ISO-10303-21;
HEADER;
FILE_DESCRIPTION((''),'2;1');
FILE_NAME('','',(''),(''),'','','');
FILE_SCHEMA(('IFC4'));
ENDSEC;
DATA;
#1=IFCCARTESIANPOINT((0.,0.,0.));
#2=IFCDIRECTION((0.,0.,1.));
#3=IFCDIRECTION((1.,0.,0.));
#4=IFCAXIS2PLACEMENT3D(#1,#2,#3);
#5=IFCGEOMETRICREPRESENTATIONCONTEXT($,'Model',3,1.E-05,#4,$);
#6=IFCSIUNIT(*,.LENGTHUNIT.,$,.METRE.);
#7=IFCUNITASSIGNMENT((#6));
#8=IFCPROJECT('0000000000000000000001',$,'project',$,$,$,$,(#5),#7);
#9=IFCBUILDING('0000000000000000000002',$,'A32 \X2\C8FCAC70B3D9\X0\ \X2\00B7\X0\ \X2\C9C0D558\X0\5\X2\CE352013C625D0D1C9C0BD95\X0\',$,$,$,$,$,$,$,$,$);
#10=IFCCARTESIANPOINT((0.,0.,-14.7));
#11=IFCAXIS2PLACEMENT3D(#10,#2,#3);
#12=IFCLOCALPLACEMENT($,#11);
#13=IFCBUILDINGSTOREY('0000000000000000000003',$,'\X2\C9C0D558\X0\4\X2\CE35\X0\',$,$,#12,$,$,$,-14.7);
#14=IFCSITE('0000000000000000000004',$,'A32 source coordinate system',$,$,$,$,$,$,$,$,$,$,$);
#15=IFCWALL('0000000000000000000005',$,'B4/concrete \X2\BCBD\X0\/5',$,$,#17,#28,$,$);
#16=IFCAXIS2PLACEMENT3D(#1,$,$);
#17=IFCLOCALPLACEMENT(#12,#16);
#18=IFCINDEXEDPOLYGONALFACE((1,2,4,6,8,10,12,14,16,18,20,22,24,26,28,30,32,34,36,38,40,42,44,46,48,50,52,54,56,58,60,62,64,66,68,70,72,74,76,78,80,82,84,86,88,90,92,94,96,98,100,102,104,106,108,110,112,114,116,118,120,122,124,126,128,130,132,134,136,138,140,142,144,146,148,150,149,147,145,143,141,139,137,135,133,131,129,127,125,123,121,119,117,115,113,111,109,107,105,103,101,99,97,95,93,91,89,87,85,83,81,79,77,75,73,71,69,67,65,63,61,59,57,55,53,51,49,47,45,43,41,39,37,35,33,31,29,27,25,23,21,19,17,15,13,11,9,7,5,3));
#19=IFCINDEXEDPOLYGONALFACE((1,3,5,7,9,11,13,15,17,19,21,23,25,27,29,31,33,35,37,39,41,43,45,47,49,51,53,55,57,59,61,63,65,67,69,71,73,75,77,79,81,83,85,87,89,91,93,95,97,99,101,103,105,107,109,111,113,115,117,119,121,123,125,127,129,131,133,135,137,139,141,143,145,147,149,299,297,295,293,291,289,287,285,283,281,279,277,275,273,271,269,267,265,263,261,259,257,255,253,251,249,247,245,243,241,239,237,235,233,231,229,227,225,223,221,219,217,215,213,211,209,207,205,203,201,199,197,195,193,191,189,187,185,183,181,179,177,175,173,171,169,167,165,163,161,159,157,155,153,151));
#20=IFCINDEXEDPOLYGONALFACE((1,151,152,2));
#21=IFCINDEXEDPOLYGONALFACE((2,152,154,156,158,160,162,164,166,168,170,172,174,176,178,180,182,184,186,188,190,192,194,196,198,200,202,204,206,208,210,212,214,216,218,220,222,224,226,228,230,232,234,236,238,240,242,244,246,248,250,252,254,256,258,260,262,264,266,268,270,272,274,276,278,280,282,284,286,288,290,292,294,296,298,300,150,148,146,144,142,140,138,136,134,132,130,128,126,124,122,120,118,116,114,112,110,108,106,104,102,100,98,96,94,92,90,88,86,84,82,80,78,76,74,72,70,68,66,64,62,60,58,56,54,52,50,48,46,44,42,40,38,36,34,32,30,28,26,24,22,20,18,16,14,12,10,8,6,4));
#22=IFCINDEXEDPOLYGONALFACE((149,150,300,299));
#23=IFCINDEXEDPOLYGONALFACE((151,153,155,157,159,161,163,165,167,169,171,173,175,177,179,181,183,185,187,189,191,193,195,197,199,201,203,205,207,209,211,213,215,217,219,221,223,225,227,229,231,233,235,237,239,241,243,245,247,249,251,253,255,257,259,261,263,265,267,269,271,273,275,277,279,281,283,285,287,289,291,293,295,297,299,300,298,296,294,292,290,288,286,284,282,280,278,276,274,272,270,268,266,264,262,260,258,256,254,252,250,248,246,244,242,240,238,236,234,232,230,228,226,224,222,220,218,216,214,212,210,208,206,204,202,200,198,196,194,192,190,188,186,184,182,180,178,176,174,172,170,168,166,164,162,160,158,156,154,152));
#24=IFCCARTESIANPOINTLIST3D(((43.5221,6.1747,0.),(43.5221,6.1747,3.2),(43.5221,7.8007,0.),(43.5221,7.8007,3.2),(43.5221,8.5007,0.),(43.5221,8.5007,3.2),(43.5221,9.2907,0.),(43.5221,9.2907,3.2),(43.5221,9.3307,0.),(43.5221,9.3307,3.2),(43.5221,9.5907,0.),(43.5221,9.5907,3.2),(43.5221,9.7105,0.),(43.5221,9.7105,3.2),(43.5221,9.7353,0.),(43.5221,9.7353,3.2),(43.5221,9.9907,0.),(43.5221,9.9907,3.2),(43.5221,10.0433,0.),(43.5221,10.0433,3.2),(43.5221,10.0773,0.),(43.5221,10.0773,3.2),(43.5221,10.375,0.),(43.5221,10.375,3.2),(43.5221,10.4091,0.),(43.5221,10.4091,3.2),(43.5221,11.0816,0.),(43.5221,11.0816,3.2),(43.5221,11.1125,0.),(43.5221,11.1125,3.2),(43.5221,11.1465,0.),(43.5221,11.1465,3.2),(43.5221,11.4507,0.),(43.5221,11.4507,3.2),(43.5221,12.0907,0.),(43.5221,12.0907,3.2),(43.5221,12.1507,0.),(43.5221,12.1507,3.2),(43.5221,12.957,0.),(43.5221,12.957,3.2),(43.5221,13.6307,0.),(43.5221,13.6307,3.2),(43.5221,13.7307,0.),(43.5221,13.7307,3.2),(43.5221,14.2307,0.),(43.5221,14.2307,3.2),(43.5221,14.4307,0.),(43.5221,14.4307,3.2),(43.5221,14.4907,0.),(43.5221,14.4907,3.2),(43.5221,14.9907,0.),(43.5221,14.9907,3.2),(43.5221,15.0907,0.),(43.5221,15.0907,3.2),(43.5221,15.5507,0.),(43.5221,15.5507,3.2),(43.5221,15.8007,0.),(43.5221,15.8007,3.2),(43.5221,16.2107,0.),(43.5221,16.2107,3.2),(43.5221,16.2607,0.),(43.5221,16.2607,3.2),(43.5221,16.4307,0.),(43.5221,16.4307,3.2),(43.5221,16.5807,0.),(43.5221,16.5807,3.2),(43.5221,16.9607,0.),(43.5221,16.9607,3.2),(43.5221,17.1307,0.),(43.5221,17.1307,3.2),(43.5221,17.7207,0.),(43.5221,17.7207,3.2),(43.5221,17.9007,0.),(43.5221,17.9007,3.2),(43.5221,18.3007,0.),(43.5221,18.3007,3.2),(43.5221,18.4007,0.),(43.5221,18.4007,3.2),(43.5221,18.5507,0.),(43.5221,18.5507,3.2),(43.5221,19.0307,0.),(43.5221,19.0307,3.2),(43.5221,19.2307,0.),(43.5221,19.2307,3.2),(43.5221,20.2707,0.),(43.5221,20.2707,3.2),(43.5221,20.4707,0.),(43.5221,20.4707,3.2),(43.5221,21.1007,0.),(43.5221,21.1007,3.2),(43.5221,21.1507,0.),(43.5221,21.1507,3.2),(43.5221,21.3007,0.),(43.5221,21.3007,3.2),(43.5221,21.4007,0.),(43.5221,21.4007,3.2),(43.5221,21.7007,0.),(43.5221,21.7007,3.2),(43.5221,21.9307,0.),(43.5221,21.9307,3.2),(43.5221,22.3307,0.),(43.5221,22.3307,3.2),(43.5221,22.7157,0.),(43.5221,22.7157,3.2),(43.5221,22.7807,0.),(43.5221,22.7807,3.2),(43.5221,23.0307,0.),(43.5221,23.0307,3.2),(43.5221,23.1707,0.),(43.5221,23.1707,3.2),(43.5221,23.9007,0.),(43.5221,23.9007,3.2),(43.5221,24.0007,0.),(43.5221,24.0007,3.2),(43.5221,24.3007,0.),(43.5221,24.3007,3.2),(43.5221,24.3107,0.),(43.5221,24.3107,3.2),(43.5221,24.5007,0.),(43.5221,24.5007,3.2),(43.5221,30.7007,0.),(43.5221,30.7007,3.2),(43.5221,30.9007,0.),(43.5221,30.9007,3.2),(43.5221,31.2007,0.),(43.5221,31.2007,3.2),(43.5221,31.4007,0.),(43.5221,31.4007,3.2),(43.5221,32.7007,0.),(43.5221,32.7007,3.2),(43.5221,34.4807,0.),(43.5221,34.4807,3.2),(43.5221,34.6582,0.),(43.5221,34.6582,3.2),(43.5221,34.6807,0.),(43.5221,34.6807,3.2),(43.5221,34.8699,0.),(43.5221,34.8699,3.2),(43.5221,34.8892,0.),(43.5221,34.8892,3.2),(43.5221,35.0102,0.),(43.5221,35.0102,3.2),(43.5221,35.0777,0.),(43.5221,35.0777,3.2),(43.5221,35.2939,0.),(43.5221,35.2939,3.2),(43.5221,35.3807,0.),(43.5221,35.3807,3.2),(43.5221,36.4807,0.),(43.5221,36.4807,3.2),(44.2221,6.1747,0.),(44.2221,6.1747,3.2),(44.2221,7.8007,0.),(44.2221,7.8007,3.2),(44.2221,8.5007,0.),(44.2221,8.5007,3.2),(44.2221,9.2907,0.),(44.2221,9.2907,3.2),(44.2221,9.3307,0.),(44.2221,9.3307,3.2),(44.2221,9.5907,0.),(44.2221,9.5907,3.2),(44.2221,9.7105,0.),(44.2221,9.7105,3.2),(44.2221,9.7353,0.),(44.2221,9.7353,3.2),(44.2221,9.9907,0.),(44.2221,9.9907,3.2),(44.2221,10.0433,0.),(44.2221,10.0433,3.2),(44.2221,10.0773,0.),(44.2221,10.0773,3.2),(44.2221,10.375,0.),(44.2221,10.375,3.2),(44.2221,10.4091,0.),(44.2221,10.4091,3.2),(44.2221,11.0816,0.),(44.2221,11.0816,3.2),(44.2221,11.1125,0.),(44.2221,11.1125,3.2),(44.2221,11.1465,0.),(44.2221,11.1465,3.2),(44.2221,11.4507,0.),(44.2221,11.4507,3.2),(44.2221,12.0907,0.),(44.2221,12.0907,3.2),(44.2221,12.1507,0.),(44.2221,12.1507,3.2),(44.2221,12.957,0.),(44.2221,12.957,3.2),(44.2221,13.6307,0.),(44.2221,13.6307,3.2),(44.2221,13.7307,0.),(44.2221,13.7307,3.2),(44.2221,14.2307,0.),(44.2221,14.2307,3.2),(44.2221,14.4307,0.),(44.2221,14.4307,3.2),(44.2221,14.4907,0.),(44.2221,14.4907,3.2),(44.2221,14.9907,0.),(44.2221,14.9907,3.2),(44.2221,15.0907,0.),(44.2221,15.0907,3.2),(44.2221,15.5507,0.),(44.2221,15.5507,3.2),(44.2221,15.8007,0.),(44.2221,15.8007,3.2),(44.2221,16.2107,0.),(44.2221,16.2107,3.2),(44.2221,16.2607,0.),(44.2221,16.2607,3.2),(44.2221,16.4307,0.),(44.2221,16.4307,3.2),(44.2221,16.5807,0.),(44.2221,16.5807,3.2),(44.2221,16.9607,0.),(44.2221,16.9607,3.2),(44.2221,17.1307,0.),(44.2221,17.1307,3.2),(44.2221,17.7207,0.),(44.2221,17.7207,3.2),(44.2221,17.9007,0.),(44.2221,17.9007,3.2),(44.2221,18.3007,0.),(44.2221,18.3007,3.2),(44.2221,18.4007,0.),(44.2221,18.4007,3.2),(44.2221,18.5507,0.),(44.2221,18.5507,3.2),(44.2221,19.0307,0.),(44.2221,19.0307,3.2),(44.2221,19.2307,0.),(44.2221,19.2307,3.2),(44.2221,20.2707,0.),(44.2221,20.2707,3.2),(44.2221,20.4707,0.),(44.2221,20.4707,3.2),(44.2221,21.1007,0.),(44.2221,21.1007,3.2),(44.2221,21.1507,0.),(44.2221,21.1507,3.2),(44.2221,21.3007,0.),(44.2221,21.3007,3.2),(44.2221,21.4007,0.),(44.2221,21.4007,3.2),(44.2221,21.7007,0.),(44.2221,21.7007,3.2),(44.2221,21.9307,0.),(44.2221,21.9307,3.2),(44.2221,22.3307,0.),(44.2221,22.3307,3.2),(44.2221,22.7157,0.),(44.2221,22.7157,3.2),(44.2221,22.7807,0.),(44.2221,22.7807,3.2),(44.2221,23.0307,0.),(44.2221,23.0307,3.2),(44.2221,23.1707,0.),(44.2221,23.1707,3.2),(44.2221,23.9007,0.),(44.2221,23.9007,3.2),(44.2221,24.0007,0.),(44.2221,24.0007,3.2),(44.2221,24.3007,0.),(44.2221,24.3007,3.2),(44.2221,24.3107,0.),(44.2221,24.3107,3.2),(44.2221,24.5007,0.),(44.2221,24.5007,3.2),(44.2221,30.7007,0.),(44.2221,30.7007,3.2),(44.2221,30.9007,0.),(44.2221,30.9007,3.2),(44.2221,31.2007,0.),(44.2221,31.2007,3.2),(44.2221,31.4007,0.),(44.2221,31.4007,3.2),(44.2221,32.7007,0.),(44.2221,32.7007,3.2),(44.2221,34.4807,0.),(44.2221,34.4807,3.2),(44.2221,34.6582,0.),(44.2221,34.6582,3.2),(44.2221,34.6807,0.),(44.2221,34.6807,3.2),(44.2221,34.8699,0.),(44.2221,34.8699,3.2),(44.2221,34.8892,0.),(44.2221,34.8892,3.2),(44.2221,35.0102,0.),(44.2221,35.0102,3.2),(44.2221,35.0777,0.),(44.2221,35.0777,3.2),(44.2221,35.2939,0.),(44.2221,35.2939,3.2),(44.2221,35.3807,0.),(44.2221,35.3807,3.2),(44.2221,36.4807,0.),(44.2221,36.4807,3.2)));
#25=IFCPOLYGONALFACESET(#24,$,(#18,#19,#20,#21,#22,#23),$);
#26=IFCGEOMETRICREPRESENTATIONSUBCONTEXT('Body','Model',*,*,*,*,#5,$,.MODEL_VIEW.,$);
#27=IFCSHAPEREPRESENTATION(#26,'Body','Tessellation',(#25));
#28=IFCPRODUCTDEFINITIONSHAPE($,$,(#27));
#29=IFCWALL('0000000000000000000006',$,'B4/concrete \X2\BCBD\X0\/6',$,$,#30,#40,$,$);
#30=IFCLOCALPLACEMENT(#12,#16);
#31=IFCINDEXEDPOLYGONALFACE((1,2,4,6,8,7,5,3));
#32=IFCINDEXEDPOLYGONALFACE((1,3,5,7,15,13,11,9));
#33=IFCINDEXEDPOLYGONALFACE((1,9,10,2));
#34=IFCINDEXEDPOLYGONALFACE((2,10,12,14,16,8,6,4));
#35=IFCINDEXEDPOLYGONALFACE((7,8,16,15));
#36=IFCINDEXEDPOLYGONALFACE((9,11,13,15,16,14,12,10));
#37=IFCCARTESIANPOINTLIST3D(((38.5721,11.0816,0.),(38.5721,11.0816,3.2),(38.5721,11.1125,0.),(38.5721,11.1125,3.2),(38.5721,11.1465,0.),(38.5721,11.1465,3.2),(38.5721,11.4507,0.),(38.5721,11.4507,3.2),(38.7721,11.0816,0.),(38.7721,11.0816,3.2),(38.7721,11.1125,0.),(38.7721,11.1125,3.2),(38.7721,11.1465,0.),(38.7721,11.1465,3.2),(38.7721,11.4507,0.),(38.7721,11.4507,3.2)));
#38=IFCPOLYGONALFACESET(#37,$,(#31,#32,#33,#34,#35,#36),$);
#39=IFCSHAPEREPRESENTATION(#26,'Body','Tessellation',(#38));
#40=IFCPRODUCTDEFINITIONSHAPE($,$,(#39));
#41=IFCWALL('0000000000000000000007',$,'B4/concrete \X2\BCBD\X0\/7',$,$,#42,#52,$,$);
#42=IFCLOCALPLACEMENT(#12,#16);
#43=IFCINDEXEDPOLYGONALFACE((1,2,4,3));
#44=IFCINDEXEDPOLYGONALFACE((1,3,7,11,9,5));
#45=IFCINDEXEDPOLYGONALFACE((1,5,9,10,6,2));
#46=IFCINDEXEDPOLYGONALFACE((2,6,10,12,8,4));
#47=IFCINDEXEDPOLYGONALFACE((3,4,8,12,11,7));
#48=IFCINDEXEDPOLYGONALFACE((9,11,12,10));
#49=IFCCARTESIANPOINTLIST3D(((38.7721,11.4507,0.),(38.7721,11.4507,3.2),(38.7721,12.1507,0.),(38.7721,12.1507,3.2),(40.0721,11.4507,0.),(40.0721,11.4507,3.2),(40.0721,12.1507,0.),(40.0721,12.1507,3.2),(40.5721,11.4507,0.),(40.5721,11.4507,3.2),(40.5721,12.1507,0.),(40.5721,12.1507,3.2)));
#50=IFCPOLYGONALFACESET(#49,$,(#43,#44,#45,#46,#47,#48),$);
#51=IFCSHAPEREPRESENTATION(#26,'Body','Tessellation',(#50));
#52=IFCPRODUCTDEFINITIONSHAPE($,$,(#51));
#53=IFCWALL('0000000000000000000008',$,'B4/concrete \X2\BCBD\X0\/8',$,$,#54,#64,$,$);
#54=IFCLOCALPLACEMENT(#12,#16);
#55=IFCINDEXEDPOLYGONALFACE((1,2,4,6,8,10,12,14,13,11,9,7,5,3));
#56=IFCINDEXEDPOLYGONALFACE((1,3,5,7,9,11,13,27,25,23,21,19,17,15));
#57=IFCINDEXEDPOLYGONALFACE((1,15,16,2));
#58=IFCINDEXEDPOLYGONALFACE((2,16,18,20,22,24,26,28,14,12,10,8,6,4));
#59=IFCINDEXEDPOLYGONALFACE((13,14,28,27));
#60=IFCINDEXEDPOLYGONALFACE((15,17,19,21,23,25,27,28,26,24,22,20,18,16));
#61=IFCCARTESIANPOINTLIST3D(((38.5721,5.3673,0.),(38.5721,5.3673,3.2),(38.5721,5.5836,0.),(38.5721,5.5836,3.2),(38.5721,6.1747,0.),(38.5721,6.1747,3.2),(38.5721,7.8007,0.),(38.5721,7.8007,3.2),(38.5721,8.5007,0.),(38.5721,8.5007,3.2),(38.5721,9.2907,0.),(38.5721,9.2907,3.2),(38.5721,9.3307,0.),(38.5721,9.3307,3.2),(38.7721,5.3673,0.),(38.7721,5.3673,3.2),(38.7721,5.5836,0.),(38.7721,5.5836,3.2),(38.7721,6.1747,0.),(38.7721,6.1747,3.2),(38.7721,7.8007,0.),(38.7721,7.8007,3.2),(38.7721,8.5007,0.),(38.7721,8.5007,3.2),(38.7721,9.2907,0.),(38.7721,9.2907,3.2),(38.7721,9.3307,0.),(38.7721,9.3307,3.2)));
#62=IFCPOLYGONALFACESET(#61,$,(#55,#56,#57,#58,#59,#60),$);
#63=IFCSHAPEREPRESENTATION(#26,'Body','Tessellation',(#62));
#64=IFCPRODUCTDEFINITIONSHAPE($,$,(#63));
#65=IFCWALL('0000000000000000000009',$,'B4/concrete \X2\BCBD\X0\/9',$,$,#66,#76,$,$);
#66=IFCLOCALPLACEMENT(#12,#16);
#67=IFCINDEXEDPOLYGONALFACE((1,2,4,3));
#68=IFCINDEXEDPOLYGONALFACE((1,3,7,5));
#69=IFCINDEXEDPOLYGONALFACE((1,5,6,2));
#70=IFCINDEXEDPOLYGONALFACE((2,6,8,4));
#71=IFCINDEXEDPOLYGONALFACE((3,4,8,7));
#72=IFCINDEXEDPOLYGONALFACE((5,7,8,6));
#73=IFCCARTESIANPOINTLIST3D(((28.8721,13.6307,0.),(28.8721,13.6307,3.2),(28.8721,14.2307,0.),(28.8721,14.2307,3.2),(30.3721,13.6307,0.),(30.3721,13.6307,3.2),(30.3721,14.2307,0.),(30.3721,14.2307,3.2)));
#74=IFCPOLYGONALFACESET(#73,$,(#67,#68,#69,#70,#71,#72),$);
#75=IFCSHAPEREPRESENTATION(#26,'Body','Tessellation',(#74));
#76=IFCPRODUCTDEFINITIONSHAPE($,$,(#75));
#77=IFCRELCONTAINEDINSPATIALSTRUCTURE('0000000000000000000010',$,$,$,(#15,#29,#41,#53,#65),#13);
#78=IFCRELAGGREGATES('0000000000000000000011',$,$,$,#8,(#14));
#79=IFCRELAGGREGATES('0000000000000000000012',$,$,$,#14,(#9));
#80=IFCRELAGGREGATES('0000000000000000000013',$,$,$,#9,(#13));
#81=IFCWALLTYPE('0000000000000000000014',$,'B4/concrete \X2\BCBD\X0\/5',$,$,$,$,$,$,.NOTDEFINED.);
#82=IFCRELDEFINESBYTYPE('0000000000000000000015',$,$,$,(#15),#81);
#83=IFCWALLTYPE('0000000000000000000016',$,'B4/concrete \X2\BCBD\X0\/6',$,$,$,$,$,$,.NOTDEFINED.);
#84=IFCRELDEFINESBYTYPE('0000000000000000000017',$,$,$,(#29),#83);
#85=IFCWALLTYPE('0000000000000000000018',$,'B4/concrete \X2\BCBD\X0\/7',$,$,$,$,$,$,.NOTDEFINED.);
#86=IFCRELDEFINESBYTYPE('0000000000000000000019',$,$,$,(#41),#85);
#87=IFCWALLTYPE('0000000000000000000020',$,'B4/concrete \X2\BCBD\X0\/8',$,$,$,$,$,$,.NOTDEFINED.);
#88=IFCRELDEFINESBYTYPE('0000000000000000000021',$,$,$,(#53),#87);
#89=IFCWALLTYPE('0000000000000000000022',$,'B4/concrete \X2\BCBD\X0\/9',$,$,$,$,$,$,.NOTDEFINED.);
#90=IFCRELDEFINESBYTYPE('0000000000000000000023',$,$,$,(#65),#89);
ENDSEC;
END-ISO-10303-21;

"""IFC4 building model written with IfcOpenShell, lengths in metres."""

from ifc_helpers import new_model, si_unit, frame, origin, origin_with_axes, place, context, subcontext, project, spatial, polyline, outline, extrude, source, transform, mapped, type_object, type_shapes, element, save


model = new_model("IFC4")

# Units and contexts
model_context = context("Model", 3, precision=1e-05, world=origin_with_axes())
body_context = subcontext(model_context, "Body", "Model", "MODEL_VIEW")
ifc_project = project(units=[si_unit("LENGTHUNIT", "METRE")], contexts=[model_context])

# Site, building, storey
site = spatial("IfcSite", under=ifc_project, Name="A32 source coordinate system")
building = spatial("IfcBuilding", under=site, Name="A32 주거동 · 지하5층–옥탑지붕")
storey_placement = place(None, frame((0.0, 0.0, -14.7), z_axis=(0.0, 0.0, 1.0), x_axis=(1.0, 0.0, 0.0)))
storey = spatial("IfcBuildingStorey", under=building, at=storey_placement, Name="지하4층", Elevation=-14.7)

# Walls
wall_type_1 = type_object("IfcWallType", Name="B4/concrete 벽/5", PredefinedType="NOTDEFINED")
shared_shape_1 = source(origin(), body_context, "Body", "SweptSolid", [
    extrude(outline(polyline([(44.2221, 35.2939), (44.2221, 35.0777), (44.2221, 35.0102), (44.2221, 34.8892), (44.2221, 34.8699), (44.2221, 34.6807), (44.2221, 34.6582), (44.2221, 34.4807), (44.2221, 32.7007), (44.2221, 31.4007), (44.2221, 31.2007), (44.2221, 30.9007), (44.2221, 30.7007), (44.2221, 24.5007), (44.2221, 24.3107), (44.2221, 24.3007), (44.2221, 24.0007), (44.2221, 23.9007), (44.2221, 23.1707), (44.2221, 23.0307), (44.2221, 22.7807), (44.2221, 22.7157), (44.2221, 22.3307), (44.2221, 21.9307), (44.2221, 21.7007), (44.2221, 21.4007), (44.2221, 21.3007), (44.2221, 21.1507), (44.2221, 21.1007), (44.2221, 20.4707), (44.2221, 20.2707), (44.2221, 19.2307), (44.2221, 19.0307), (44.2221, 18.5507), (44.2221, 18.4007), (44.2221, 18.3007), (44.2221, 17.9007), (44.2221, 17.7207), (44.2221, 17.1307), (44.2221, 16.9607), (44.2221, 16.5807), (44.2221, 16.4307), (44.2221, 16.2607), (44.2221, 16.2107), (44.2221, 15.8007), (44.2221, 15.5507), (44.2221, 15.0907), (44.2221, 14.9907), (44.2221, 14.4907), (44.2221, 14.4307), (44.2221, 14.2307), (44.2221, 13.7307), (44.2221, 13.6307), (44.2221, 12.957), (44.2221, 12.1507), (44.2221, 12.0907), (44.2221, 11.4507), (44.2221, 11.1465), (44.2221, 11.1125), (44.2221, 11.0816), (44.2221, 10.4091), (44.2221, 10.375), (44.2221, 10.0773), (44.2221, 10.0433), (44.2221, 9.9907), (44.2221, 9.7353), (44.2221, 9.7105), (44.2221, 9.5907), (44.2221, 9.3307), (44.2221, 9.2907), (44.2221, 8.5007), (44.2221, 7.8007), (44.2221, 6.1747), (43.5221, 6.1747), (43.5221, 7.8007), (43.5221, 8.5007), (43.5221, 9.2907), (43.5221, 9.3307), (43.5221, 9.5907), (43.5221, 9.7105), (43.5221, 9.7353), (43.5221, 9.9907), (43.5221, 10.0433), (43.5221, 10.0773), (43.5221, 10.375), (43.5221, 10.4091), (43.5221, 11.0816), (43.5221, 11.1125), (43.5221, 11.1465), (43.5221, 11.4507), (43.5221, 12.0907), (43.5221, 12.1507), (43.5221, 12.957), (43.5221, 13.6307), (43.5221, 13.7307), (43.5221, 14.2307), (43.5221, 14.4307), (43.5221, 14.4907), (43.5221, 14.9907), (43.5221, 15.0907), (43.5221, 15.5507), (43.5221, 15.8007), (43.5221, 16.2107), (43.5221, 16.2607), (43.5221, 16.4307), (43.5221, 16.5807), (43.5221, 16.9607), (43.5221, 17.1307), (43.5221, 17.7207), (43.5221, 17.9007), (43.5221, 18.3007), (43.5221, 18.4007), (43.5221, 18.5507), (43.5221, 19.0307), (43.5221, 19.2307), (43.5221, 20.2707), (43.5221, 20.4707), (43.5221, 21.1007), (43.5221, 21.1507), (43.5221, 21.3007), (43.5221, 21.4007), (43.5221, 21.7007), (43.5221, 21.9307), (43.5221, 22.3307), (43.5221, 22.7157), (43.5221, 22.7807), (43.5221, 23.0307), (43.5221, 23.1707), (43.5221, 23.9007), (43.5221, 24.0007), (43.5221, 24.3007), (43.5221, 24.3107), (43.5221, 24.5007), (43.5221, 30.7007), (43.5221, 30.9007), (43.5221, 31.2007), (43.5221, 31.4007), (43.5221, 32.7007), (43.5221, 34.4807), (43.5221, 34.6582), (43.5221, 34.6807), (43.5221, 34.8699), (43.5221, 34.8892), (43.5221, 35.0102), (43.5221, 35.0777), (43.5221, 35.2939), (43.5221, 35.3807), (43.5221, 36.4807), (44.2221, 36.4807), (44.2221, 35.3807), (44.2221, 35.2939)])), origin(), (0.0, 0.0, 1.0), 3.2),
])
type_shapes(wall_type_1, [shared_shape_1])
wall_1_placement = place(storey_placement, origin_with_axes())
element("IfcWall", 1, at=wall_1_placement, inside=storey, type_object=wall_type_1, Name="B4/concrete 벽/5", context=body_context, shape_type="MappedRepresentation", body=[
    mapped(shared_shape_1, transform((0.0, 0.0, 0.0), scale=1.0)),
])
wall_type_2 = type_object("IfcWallType", Name="B4/concrete 벽/6", PredefinedType="NOTDEFINED")
shared_shape_2 = source(origin(), body_context, "Body", "SweptSolid", [
    extrude(outline(polyline([(38.5721, 11.4507), (38.7721, 11.4507), (38.7721, 11.1465), (38.7721, 11.1125), (38.7721, 11.0816), (38.5721, 11.0816), (38.5721, 11.1125), (38.5721, 11.1465), (38.5721, 11.4507)])), origin(), (0.0, 0.0, 1.0), 3.2),
])
type_shapes(wall_type_2, [shared_shape_2])
wall_2_placement = place(storey_placement, origin_with_axes())
element("IfcWall", 2, at=wall_2_placement, inside=storey, type_object=wall_type_2, Name="B4/concrete 벽/6", context=body_context, shape_type="MappedRepresentation", body=[
    mapped(shared_shape_2, transform((0.0, 0.0, 0.0), scale=1.0)),
])
wall_type_3 = type_object("IfcWallType", Name="B4/concrete 벽/7", PredefinedType="NOTDEFINED")
shared_shape_3 = source(origin(), body_context, "Body", "SweptSolid", [
    extrude(outline(polyline([(40.5721, 12.1507), (40.5721, 11.4507), (40.0721, 11.4507), (38.7721, 11.4507), (38.7721, 12.1507), (40.0721, 12.1507), (40.5721, 12.1507)])), origin(), (0.0, 0.0, 1.0), 3.2),
])
type_shapes(wall_type_3, [shared_shape_3])
wall_3_placement = place(storey_placement, origin_with_axes())
element("IfcWall", 3, at=wall_3_placement, inside=storey, type_object=wall_type_3, Name="B4/concrete 벽/7", context=body_context, shape_type="MappedRepresentation", body=[
    mapped(shared_shape_3, transform((0.0, 0.0, 0.0), scale=1.0)),
])
wall_type_4 = type_object("IfcWallType", Name="B4/concrete 벽/8", PredefinedType="NOTDEFINED")
shared_shape_4 = source(origin(), body_context, "Body", "SweptSolid", [
    extrude(outline(polyline([(38.7721, 6.1747), (38.7721, 5.5836), (38.7721, 5.3673), (38.5721, 5.3673), (38.5721, 5.5836), (38.5721, 6.1747), (38.5721, 7.8007), (38.5721, 8.5007), (38.5721, 9.2907), (38.5721, 9.3307), (38.7721, 9.3307), (38.7721, 9.2907), (38.7721, 8.5007), (38.7721, 7.8007), (38.7721, 6.1747)])), origin(), (0.0, 0.0, 1.0), 3.2),
])
type_shapes(wall_type_4, [shared_shape_4])
wall_4_placement = place(storey_placement, origin_with_axes())
element("IfcWall", 4, at=wall_4_placement, inside=storey, type_object=wall_type_4, Name="B4/concrete 벽/8", context=body_context, shape_type="MappedRepresentation", body=[
    mapped(shared_shape_4, transform((0.0, 0.0, 0.0), scale=1.0)),
])
wall_type_5 = type_object("IfcWallType", Name="B4/concrete 벽/9", PredefinedType="NOTDEFINED")
shared_shape_5 = source(origin(), body_context, "Body", "SweptSolid", [
    extrude(outline(polyline([(30.3721, 13.6307), (28.8721, 13.6307), (28.8721, 14.2307), (30.3721, 14.2307), (30.3721, 13.6307)])), origin(), (0.0, 0.0, 1.0), 3.2),
])
type_shapes(wall_type_5, [shared_shape_5])
wall_5_placement = place(storey_placement, origin_with_axes())
element("IfcWall", 5, at=wall_5_placement, inside=storey, type_object=wall_type_5, Name="B4/concrete 벽/9", context=body_context, shape_type="MappedRepresentation", body=[
    mapped(shared_shape_5, transform((0.0, 0.0, 0.0), scale=1.0)),
])

save(model, "model.ifc")
